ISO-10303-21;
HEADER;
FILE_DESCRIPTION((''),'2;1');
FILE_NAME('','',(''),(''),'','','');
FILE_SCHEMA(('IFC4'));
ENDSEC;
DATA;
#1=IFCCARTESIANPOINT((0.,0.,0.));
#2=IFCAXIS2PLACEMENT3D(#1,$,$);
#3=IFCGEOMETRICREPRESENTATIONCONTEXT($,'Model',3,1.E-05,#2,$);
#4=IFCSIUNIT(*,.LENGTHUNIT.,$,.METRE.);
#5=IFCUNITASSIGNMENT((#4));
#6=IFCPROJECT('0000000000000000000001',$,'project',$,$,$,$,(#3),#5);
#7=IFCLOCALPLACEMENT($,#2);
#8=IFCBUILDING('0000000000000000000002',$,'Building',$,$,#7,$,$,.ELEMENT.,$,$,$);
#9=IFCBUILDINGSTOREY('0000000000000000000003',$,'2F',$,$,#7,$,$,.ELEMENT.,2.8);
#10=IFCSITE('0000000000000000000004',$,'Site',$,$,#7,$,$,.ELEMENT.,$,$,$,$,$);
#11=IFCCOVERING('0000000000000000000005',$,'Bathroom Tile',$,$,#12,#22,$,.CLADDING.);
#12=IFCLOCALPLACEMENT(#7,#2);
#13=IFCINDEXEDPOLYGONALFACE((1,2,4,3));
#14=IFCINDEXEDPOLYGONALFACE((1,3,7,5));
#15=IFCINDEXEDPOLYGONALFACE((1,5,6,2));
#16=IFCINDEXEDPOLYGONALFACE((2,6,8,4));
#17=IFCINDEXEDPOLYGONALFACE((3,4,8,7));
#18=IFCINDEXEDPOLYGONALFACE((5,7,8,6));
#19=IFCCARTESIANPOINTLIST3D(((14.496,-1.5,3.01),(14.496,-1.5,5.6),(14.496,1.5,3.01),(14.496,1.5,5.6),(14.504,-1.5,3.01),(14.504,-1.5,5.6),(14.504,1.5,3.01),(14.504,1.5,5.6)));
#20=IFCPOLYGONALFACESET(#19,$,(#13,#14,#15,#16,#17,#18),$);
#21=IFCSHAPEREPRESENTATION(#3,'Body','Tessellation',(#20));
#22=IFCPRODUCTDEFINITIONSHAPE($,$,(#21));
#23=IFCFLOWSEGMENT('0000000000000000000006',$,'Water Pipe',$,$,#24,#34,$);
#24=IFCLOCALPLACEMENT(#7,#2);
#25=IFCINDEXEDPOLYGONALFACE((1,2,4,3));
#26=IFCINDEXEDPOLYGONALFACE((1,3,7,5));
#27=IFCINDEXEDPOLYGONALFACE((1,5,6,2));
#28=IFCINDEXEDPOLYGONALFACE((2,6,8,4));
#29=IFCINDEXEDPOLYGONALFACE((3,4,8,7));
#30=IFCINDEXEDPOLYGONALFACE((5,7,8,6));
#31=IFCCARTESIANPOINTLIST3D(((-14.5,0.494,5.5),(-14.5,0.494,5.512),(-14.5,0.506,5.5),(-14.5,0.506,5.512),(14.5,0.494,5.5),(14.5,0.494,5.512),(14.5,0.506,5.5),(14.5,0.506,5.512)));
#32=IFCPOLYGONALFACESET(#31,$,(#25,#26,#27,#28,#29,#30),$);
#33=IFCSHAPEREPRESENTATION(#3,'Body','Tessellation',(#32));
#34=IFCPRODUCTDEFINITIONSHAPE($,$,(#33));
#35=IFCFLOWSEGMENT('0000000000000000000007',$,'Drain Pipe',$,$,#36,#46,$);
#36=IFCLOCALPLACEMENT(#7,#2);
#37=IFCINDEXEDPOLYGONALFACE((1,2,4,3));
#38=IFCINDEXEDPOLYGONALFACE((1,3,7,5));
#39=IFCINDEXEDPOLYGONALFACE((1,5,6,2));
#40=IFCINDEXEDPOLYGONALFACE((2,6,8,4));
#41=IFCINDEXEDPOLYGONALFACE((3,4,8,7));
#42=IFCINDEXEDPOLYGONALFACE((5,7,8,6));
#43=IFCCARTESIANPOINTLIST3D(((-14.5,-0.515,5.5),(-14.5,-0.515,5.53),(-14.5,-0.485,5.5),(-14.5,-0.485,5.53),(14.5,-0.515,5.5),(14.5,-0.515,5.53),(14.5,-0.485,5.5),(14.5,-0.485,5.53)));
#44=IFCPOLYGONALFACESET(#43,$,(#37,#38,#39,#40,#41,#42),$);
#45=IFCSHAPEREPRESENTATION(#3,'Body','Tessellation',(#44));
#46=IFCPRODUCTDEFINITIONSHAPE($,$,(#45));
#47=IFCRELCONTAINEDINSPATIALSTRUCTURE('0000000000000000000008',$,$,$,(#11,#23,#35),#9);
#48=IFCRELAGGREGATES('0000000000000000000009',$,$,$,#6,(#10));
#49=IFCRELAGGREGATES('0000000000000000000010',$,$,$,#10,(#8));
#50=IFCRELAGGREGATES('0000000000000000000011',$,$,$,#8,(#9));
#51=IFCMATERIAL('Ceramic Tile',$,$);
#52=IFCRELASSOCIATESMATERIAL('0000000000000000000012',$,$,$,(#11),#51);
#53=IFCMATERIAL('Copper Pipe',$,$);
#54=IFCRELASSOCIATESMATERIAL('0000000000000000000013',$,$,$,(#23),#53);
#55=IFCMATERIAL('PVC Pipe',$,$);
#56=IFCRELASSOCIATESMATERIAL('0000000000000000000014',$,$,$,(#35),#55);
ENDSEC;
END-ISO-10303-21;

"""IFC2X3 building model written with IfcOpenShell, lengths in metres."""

from ifc_helpers import new_model, si_unit, frame, origin, origin_2d, place, context, project, spatial, rectangle, extrude, material, element, save


model = new_model("IFC2X3")

# Units and contexts
model_context = context("Model", 3, precision=1e-05, world=origin())
ifc_project = project(units=[si_unit("LENGTHUNIT", "METRE")], contexts=[model_context])

# Site, building, storey
placement = place(None, origin())
site = spatial("IfcSite", under=ifc_project, at=placement, Name="Site", CompositionType="ELEMENT")
building = spatial("IfcBuilding", under=site, at=placement, Name="Building", CompositionType="ELEMENT")
storey = spatial("IfcBuildingStorey", under=building, at=placement, Name="2F", CompositionType="ELEMENT", Elevation=2.8)

# Covering
ifc_material_1 = material(Name="Ceramic Tile")
covering_1_placement = place(None, frame((14.5, 0.0, 3.01)))
element("IfcCovering", 1, at=covering_1_placement, inside=storey, material=ifc_material_1, Name="Bathroom Tile", PredefinedType="CLADDING", context=model_context, shape_type="SweptSolid", body=[
    extrude(rectangle(XDim=0.008, YDim=3.0, at=origin_2d()), origin(), (0.0, 0.0, 1.0), 2.59),
])

# Flow segments
ifc_material_2 = material(Name="Copper Pipe")
flow_segment_1_placement = place(None, frame((0.0, 0.5, 5.5)))
element("IfcFlowSegment", 2, at=flow_segment_1_placement, inside=storey, material=ifc_material_2, Name="Water Pipe", context=model_context, shape_type="SweptSolid", body=[
    extrude(rectangle(XDim=29.0, YDim=0.012, at=origin_2d()), origin(), (0.0, 0.0, 1.0), 0.012),
])
ifc_material_3 = material(Name="PVC Pipe")
flow_segment_2_placement = place(None, frame((0.0, -0.5, 5.5)))
element("IfcFlowSegment", 3, at=flow_segment_2_placement, inside=storey, material=ifc_material_3, Name="Drain Pipe", context=model_context, shape_type="SweptSolid", body=[
    extrude(rectangle(XDim=29.0, YDim=0.03, at=origin_2d()), origin(), (0.0, 0.0, 1.0), 0.03),
])

save(model, "model.ifc")
